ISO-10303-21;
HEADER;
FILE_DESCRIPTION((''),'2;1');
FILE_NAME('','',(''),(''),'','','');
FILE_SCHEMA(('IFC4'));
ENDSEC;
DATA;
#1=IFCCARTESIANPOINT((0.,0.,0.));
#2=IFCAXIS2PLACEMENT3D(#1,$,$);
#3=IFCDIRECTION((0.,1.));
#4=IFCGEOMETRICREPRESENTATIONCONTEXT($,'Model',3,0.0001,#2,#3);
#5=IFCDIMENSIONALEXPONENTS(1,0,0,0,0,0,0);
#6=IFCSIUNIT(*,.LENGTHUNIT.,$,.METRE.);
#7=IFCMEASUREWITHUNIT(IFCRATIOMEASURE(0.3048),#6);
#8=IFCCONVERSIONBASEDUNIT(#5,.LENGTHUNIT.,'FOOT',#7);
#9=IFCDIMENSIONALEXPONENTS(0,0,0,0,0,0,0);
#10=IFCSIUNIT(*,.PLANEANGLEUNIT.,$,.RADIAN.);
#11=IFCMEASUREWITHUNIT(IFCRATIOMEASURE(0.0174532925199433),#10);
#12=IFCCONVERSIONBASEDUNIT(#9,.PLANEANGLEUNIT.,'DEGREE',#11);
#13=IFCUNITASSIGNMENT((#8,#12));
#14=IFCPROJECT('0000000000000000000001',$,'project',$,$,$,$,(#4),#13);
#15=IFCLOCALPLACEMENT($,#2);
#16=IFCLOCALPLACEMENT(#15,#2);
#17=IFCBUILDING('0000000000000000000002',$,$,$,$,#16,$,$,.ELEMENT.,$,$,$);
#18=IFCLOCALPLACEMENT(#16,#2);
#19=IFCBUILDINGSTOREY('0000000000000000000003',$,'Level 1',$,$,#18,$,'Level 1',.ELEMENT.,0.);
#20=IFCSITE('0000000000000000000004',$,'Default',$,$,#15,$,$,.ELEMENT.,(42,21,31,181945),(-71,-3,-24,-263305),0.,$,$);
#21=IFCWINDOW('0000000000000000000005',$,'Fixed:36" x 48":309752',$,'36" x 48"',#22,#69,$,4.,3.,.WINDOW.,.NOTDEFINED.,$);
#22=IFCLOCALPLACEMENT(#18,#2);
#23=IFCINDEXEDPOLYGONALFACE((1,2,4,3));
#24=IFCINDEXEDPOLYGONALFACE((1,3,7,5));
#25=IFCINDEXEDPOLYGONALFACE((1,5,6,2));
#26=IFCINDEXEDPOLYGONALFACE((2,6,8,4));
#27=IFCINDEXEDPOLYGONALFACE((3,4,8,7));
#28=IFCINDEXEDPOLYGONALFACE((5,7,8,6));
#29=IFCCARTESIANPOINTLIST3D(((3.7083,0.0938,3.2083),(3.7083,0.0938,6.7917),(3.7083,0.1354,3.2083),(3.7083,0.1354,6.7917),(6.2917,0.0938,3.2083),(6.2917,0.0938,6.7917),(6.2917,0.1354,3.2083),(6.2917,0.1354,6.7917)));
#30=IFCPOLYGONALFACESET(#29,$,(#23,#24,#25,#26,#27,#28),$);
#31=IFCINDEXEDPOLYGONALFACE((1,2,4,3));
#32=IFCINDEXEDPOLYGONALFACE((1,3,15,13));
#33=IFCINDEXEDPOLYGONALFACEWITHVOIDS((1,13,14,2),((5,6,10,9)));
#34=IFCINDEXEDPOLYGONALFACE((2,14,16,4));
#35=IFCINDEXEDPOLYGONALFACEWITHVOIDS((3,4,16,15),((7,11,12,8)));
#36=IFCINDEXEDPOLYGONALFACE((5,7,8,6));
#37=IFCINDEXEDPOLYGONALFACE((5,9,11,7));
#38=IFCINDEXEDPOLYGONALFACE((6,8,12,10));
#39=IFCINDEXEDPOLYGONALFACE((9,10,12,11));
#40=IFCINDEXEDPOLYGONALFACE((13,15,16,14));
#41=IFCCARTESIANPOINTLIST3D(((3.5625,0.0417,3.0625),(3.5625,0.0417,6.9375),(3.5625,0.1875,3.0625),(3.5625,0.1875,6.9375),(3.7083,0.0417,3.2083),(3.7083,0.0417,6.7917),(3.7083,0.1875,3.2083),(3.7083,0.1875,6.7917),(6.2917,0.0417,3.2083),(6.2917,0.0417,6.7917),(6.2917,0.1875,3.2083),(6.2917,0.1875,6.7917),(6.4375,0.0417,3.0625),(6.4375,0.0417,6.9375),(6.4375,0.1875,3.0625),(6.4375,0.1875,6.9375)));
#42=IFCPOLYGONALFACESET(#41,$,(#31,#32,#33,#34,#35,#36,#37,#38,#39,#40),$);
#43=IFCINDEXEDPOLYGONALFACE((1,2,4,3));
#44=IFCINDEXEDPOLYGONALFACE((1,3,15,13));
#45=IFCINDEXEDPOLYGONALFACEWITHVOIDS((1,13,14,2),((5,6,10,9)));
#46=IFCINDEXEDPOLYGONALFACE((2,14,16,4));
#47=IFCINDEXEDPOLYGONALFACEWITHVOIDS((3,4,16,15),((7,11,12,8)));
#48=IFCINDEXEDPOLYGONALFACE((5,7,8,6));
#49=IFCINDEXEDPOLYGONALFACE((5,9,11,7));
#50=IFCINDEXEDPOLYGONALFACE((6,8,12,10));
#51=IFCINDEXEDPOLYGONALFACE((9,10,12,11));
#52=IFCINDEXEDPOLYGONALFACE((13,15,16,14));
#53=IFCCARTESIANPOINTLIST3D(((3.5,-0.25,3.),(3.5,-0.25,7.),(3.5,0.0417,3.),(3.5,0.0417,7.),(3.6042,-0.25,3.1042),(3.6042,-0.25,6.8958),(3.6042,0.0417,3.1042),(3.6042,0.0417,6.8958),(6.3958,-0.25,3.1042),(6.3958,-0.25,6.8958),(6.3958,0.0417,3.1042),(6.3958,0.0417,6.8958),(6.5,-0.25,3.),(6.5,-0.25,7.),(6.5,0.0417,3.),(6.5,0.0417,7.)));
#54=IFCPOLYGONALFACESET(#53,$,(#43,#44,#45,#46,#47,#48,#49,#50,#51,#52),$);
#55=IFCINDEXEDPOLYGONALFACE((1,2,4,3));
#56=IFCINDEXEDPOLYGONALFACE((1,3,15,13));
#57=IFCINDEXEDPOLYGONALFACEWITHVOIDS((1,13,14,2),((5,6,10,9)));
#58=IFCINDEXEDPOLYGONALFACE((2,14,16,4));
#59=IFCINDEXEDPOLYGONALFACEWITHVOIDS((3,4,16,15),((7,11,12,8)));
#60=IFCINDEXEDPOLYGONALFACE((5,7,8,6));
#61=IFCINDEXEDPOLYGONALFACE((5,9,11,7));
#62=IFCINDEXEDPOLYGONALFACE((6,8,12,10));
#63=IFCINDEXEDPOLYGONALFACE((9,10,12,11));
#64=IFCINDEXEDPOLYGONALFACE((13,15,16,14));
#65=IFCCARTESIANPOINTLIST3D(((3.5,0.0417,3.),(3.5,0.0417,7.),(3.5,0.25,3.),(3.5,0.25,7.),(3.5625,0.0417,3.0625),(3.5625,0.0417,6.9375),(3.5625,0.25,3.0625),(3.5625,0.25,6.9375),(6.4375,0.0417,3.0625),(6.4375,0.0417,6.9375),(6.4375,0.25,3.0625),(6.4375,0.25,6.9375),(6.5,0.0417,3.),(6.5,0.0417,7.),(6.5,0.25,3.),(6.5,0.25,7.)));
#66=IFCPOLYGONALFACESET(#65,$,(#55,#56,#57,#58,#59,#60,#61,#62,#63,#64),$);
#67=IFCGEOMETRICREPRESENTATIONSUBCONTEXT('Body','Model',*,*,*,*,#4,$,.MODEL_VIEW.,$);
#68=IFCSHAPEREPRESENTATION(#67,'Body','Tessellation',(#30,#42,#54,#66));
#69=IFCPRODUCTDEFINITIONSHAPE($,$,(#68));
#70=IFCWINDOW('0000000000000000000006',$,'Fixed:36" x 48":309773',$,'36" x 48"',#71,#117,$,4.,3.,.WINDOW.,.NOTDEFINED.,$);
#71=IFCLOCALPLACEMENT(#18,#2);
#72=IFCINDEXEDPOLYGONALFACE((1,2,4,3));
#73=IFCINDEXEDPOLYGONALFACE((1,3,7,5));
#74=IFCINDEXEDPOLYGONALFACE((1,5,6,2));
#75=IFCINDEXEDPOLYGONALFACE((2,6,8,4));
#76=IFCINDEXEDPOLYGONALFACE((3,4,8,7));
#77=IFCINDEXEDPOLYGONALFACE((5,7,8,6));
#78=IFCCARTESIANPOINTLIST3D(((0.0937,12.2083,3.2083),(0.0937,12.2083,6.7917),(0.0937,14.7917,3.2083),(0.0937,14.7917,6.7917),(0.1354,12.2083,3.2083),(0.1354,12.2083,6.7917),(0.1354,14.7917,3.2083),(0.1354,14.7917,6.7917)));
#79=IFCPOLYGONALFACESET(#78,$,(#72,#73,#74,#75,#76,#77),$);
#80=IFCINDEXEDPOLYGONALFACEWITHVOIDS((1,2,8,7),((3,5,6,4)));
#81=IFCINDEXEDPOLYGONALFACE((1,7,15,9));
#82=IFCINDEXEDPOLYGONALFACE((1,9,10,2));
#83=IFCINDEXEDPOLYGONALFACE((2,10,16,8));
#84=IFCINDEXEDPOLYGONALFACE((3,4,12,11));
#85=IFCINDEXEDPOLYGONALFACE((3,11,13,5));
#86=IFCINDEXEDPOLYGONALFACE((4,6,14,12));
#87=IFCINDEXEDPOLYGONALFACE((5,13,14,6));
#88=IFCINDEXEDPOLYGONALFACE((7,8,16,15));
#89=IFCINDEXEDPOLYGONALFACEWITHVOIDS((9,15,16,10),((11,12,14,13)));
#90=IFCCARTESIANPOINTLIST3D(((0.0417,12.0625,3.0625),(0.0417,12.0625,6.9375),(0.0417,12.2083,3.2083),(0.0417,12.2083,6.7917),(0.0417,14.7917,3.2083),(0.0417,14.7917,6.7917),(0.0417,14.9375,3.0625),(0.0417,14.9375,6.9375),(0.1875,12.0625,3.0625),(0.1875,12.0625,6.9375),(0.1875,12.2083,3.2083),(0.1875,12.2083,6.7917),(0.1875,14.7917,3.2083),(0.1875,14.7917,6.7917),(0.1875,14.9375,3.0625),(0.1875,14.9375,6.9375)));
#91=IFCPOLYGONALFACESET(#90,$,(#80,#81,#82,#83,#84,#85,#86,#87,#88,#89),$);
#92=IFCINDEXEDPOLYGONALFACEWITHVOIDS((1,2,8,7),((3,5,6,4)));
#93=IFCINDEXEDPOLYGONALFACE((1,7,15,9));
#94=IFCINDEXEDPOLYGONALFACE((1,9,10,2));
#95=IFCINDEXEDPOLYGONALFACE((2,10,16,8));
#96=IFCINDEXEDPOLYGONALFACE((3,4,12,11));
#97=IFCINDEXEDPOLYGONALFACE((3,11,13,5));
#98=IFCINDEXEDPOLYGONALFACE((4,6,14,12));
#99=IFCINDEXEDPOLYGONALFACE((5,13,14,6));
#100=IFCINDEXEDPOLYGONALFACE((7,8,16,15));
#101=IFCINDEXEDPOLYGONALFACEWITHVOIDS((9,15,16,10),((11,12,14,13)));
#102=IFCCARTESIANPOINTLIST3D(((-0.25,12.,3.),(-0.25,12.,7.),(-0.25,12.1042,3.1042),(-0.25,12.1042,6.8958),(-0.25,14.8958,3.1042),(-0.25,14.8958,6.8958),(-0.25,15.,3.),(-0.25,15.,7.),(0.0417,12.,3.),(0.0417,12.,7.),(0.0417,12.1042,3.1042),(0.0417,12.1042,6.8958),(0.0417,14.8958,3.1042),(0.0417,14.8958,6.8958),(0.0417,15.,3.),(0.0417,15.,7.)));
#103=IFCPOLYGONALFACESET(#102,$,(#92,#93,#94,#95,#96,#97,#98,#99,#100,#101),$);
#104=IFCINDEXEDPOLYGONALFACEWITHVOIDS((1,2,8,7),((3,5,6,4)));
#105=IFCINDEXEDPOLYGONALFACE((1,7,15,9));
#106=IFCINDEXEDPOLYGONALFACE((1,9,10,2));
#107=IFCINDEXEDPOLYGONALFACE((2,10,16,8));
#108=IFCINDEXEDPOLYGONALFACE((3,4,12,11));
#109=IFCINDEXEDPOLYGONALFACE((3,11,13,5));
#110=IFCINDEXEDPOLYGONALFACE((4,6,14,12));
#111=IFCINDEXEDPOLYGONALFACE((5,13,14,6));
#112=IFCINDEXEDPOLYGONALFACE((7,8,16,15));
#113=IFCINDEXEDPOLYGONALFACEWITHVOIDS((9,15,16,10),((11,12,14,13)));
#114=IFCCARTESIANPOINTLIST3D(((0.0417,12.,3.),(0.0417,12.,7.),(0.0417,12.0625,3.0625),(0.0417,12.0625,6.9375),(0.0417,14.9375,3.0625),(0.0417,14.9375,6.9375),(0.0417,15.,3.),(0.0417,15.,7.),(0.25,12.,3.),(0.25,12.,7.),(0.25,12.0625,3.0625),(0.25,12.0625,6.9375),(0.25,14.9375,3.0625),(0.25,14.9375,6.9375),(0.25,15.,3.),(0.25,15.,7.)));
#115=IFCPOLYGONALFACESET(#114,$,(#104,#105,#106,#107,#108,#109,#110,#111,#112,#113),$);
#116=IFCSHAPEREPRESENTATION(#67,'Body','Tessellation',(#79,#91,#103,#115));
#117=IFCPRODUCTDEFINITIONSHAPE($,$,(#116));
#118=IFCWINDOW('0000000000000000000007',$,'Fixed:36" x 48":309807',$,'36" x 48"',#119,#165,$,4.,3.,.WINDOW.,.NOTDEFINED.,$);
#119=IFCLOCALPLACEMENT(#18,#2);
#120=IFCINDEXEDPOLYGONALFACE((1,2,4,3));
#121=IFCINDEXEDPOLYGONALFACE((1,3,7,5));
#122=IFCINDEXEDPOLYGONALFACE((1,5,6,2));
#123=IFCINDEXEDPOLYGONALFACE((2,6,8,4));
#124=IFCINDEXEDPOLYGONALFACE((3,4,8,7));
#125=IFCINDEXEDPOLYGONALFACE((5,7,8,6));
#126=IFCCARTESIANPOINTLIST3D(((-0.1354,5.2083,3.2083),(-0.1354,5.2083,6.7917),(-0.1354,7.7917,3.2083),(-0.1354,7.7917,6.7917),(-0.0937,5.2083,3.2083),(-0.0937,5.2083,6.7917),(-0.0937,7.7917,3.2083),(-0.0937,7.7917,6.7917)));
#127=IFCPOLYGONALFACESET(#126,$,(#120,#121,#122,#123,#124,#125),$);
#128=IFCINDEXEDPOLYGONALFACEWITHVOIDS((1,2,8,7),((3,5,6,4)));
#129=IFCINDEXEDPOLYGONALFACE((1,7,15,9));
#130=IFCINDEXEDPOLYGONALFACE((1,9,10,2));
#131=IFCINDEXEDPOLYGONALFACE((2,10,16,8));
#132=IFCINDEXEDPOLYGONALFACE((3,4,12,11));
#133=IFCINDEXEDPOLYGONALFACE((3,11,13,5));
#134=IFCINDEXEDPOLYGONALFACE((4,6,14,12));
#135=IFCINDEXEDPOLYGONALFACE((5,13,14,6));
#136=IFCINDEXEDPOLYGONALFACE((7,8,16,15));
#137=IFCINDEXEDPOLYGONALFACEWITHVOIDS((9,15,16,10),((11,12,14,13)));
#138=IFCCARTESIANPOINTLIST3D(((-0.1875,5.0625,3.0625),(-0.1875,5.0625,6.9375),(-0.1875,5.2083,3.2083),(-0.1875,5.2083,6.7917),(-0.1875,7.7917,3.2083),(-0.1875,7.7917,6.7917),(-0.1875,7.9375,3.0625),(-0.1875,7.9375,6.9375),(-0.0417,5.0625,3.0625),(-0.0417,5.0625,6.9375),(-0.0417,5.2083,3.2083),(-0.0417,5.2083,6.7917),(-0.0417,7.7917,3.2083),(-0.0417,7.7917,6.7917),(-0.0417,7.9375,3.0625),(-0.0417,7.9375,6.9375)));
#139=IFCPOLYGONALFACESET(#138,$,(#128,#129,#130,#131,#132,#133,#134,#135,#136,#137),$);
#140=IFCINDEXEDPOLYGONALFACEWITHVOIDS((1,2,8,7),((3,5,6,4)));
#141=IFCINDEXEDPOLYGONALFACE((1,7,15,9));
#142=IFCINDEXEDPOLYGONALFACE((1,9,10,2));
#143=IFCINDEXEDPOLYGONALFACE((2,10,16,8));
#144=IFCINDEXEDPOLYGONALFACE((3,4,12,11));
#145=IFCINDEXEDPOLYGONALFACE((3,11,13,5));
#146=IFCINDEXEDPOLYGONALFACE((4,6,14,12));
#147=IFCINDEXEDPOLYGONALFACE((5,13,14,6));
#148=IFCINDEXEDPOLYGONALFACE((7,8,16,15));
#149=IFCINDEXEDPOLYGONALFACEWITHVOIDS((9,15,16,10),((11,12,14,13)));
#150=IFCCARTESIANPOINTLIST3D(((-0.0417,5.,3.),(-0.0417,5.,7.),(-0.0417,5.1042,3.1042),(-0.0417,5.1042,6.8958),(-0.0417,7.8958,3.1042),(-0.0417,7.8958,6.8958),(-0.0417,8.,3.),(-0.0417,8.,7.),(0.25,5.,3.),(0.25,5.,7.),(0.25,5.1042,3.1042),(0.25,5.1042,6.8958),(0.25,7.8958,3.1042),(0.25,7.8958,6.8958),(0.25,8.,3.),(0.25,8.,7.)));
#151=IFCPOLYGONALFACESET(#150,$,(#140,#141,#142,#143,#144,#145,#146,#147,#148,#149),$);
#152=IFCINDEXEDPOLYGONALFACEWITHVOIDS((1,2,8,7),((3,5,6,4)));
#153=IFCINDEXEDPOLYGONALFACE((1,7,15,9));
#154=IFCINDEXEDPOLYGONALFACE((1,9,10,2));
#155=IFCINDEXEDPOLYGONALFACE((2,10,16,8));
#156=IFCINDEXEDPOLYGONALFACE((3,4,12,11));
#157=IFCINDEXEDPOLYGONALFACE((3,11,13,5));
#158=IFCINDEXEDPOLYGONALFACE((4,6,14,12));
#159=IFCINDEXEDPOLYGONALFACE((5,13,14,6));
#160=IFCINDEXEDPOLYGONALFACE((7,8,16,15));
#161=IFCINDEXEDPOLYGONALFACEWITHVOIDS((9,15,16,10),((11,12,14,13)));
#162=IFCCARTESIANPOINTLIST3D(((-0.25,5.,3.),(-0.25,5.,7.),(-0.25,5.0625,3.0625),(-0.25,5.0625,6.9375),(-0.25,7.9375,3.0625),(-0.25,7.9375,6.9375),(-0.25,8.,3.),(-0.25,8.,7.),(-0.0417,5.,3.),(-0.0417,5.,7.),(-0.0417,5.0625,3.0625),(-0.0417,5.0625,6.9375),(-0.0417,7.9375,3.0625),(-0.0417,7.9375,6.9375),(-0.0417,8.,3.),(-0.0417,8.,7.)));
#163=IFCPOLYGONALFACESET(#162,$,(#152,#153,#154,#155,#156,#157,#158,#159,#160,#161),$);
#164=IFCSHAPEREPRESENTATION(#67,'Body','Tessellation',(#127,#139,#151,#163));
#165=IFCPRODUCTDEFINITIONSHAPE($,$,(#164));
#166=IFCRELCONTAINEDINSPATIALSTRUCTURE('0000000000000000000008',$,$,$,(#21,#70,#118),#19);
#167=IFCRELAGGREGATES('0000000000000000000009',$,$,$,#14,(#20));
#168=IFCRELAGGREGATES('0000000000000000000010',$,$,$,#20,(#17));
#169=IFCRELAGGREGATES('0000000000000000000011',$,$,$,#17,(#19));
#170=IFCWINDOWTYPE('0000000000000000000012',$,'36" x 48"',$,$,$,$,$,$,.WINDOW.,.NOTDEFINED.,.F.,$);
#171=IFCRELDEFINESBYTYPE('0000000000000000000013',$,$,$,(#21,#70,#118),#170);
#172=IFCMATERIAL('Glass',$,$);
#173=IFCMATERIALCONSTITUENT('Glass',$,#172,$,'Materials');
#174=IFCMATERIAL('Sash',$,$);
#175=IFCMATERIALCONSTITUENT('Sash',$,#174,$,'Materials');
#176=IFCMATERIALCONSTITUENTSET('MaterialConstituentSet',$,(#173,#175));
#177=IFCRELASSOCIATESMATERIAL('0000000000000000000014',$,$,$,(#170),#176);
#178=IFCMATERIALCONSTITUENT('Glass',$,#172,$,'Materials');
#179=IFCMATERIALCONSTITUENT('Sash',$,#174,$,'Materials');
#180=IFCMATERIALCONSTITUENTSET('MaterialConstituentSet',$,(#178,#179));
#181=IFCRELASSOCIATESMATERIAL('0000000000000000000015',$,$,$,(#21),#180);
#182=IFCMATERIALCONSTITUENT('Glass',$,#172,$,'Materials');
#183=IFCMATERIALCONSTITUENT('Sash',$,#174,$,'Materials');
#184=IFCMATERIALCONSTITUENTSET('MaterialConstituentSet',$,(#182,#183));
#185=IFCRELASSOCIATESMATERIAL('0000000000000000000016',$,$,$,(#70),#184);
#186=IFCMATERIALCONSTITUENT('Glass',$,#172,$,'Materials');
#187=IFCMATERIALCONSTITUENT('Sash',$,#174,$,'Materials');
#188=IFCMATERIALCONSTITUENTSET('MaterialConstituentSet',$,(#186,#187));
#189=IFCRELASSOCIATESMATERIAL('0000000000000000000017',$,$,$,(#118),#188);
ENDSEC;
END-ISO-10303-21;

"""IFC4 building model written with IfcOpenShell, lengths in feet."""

from ifc_helpers import new_model, entity, si_unit, converted_unit, direction, frame, frame_2d, origin, place, context, subcontext, project, spatial, polyline, rectangle, outline, extrude, source, transform, mapped, material, constituent, constituent_set, type_object, type_shapes, element, save


model = new_model("IFC4")

# Units and contexts
model_context = context("Model", 3, precision=0.0001, world=origin(), true_north=direction((0.0, 1.0)))
body_context = subcontext(model_context, "Body", "Model", "MODEL_VIEW")
ifc_project = project(units=[converted_unit("LENGTHUNIT", "FOOT", entity("IfcRatioMeasure", 0.3048), si_unit("LENGTHUNIT", "METRE"), dimensions=[1, 0, 0, 0, 0, 0, 0]), converted_unit("PLANEANGLEUNIT", "DEGREE", entity("IfcRatioMeasure", 0.0174532925199433), si_unit("PLANEANGLEUNIT", "RADIAN"), dimensions=[0, 0, 0, 0, 0, 0, 0])], contexts=[model_context])

# Site, building, storey
site_placement = place(None, origin())
site = spatial("IfcSite", under=ifc_project, at=site_placement, Name="Default", CompositionType="ELEMENT", RefLatitude=(42, 21, 31, 181945), RefLongitude=(-71, -3, -24, -263305), RefElevation=0.0)
building_placement = place(site_placement, origin())
building = spatial("IfcBuilding", under=site, at=building_placement, CompositionType="ELEMENT")
storey_placement = place(building_placement, origin())
storey = spatial("IfcBuildingStorey", under=building, at=storey_placement, Name="Level 1", LongName="Level 1", CompositionType="ELEMENT", Elevation=0.0)

# Shared definitions
placement_1 = place(storey_placement, frame((0.0, -0.25, 0.0), z_axis=(0.0, 0.0, 1.0), x_axis=(0.0, 1.0, 0.0)))
placement_2 = place(storey_placement, frame((46.25, 0.0, 0.0), z_axis=(0.0, 0.0, 1.0), x_axis=(-1.0, 0.0, 0.0)))

# Windows
ifc_material_1 = material(Name="Glass")
ifc_material_2 = material(Name="Sash")
ifc_constituent_1 = constituent(ifc_material_1, Name="Glass", Category="Materials")
ifc_constituent_2 = constituent(ifc_material_2, Name="Sash", Category="Materials")
ifc_constituent_set_1 = constituent_set(constituents=[ifc_constituent_1, ifc_constituent_2], Name="MaterialConstituentSet")
window_type = type_object("IfcWindowType", Name="36\" x 48\"", ParameterTakesPrecedence=False, PartitioningType="NOTDEFINED", PredefinedType="WINDOW", material=ifc_constituent_set_1)
shared_shape_1 = source(origin(), body_context, "Body", "SweptSolid", [
    extrude(rectangle(XDim=0.0417, YDim=2.5833, at=frame_2d((0.0, 0.0), x_axis=(1.0, 0.0))), frame((1.5, 0.3646, 0.2083), z_axis=(0.0, 0.0, 1.0), x_axis=(0.0, 1.0, 0.0)), (0.0, 0.0, 1.0), 3.5833),
    extrude(outline(polyline([(-1.4375, -1.9375), (1.4375, -1.9375), (1.4375, 1.9375), (-1.4375, 1.9375), (-1.4375, -1.9375)]), holes=[polyline([(-1.2917, -1.7917), (-1.2917, 1.7917), (1.2917, 1.7917), (1.2917, -1.7917), (-1.2917, -1.7917)])]), frame((1.5, 0.2917, 2.0), z_axis=(0.0, 1.0, 0.0), x_axis=(1.0, 0.0, 0.0)), (0.0, 0.0, 1.0), 0.1458),
    extrude(outline(polyline([(-1.5, -2.0), (1.5, -2.0), (1.5, 2.0), (-1.5, 2.0), (-1.5, -2.0)]), holes=[polyline([(-1.3958, -1.8958), (-1.3958, 1.8958), (1.3958, 1.8958), (1.3958, -1.8958), (-1.3958, -1.8958)])]), frame((1.5, 0.0, 2.0), z_axis=(0.0, 1.0, 0.0), x_axis=(1.0, 0.0, 0.0)), (0.0, 0.0, 1.0), 0.2917),
    extrude(outline(polyline([(-2.0, -1.5), (2.0, -1.5), (2.0, 1.5), (-2.0, 1.5), (-2.0, -1.5)]), holes=[polyline([(-1.9375, -1.4375), (-1.9375, 1.4375), (1.9375, 1.4375), (1.9375, -1.4375), (-1.9375, -1.4375)])]), frame((1.5, 0.2917, 2.0), z_axis=(0.0, 1.0, 0.0), x_axis=(0.0, 0.0, -1.0)), (0.0, 0.0, 1.0), 0.2083),
])
type_shapes(window_type, [shared_shape_1])
ifc_constituent_3 = constituent(ifc_material_1, Name="Glass", Category="Materials")
ifc_constituent_4 = constituent(ifc_material_2, Name="Sash", Category="Materials")
ifc_constituent_set_2 = constituent_set(constituents=[ifc_constituent_3, ifc_constituent_4], Name="MaterialConstituentSet")
placement_3 = place(placement_2, frame((42.75, 0.25, 3.0)))
window_1_placement = place(placement_3, frame((0.0, 0.0, 0.0), z_axis=(0.0, 0.0, 1.0), x_axis=(-1.0, 0.0, 0.0)))
element("IfcWindow", 1, at=window_1_placement, inside=storey, type_object=window_type, material=ifc_constituent_set_2, Name="Fixed:36\" x 48\":309752", ObjectType="36\" x 48\"", OverallHeight=4.0, OverallWidth=3.0, PartitioningType="NOTDEFINED", PredefinedType="WINDOW", context=body_context, shape_type="MappedRepresentation", body=[
    mapped(shared_shape_1, transform((0.0, 0.0, 0.0), scale=1.0)),
])
ifc_constituent_5 = constituent(ifc_material_1, Name="Glass", Category="Materials")
ifc_constituent_6 = constituent(ifc_material_2, Name="Sash", Category="Materials")
ifc_constituent_set_3 = constituent_set(constituents=[ifc_constituent_5, ifc_constituent_6], Name="MaterialConstituentSet")
placement_4 = place(placement_1, frame((15.25, 0.25, 3.0)))
window_2_placement = place(placement_4, frame((0.0, 0.0, 0.0), z_axis=(0.0, 0.0, 1.0), x_axis=(-1.0, 0.0, 0.0)))
element("IfcWindow", 2, at=window_2_placement, inside=storey, type_object=window_type, material=ifc_constituent_set_3, Name="Fixed:36\" x 48\":309773", ObjectType="36\" x 48\"", OverallHeight=4.0, OverallWidth=3.0, PartitioningType="NOTDEFINED", PredefinedType="WINDOW", context=body_context, shape_type="MappedRepresentation", body=[
    mapped(shared_shape_1, transform((0.0, 0.0, 0.0), scale=1.0)),
])
ifc_constituent_7 = constituent(ifc_material_1, Name="Glass", Category="Materials")
ifc_constituent_8 = constituent(ifc_material_2, Name="Sash", Category="Materials")
ifc_constituent_set_4 = constituent_set(constituents=[ifc_constituent_7, ifc_constituent_8], Name="MaterialConstituentSet")
placement_5 = place(placement_1, frame((5.25, -0.25, 3.0)))
window_3_placement = place(placement_5, origin())
element("IfcWindow", 3, at=window_3_placement, inside=storey, type_object=window_type, material=ifc_constituent_set_4, Name="Fixed:36\" x 48\":309807", ObjectType="36\" x 48\"", OverallHeight=4.0, OverallWidth=3.0, PartitioningType="NOTDEFINED", PredefinedType="WINDOW", context=body_context, shape_type="MappedRepresentation", body=[
    mapped(shared_shape_1, transform((0.0, 0.0, 0.0), scale=1.0)),
])

save(model, "model.ifc")
